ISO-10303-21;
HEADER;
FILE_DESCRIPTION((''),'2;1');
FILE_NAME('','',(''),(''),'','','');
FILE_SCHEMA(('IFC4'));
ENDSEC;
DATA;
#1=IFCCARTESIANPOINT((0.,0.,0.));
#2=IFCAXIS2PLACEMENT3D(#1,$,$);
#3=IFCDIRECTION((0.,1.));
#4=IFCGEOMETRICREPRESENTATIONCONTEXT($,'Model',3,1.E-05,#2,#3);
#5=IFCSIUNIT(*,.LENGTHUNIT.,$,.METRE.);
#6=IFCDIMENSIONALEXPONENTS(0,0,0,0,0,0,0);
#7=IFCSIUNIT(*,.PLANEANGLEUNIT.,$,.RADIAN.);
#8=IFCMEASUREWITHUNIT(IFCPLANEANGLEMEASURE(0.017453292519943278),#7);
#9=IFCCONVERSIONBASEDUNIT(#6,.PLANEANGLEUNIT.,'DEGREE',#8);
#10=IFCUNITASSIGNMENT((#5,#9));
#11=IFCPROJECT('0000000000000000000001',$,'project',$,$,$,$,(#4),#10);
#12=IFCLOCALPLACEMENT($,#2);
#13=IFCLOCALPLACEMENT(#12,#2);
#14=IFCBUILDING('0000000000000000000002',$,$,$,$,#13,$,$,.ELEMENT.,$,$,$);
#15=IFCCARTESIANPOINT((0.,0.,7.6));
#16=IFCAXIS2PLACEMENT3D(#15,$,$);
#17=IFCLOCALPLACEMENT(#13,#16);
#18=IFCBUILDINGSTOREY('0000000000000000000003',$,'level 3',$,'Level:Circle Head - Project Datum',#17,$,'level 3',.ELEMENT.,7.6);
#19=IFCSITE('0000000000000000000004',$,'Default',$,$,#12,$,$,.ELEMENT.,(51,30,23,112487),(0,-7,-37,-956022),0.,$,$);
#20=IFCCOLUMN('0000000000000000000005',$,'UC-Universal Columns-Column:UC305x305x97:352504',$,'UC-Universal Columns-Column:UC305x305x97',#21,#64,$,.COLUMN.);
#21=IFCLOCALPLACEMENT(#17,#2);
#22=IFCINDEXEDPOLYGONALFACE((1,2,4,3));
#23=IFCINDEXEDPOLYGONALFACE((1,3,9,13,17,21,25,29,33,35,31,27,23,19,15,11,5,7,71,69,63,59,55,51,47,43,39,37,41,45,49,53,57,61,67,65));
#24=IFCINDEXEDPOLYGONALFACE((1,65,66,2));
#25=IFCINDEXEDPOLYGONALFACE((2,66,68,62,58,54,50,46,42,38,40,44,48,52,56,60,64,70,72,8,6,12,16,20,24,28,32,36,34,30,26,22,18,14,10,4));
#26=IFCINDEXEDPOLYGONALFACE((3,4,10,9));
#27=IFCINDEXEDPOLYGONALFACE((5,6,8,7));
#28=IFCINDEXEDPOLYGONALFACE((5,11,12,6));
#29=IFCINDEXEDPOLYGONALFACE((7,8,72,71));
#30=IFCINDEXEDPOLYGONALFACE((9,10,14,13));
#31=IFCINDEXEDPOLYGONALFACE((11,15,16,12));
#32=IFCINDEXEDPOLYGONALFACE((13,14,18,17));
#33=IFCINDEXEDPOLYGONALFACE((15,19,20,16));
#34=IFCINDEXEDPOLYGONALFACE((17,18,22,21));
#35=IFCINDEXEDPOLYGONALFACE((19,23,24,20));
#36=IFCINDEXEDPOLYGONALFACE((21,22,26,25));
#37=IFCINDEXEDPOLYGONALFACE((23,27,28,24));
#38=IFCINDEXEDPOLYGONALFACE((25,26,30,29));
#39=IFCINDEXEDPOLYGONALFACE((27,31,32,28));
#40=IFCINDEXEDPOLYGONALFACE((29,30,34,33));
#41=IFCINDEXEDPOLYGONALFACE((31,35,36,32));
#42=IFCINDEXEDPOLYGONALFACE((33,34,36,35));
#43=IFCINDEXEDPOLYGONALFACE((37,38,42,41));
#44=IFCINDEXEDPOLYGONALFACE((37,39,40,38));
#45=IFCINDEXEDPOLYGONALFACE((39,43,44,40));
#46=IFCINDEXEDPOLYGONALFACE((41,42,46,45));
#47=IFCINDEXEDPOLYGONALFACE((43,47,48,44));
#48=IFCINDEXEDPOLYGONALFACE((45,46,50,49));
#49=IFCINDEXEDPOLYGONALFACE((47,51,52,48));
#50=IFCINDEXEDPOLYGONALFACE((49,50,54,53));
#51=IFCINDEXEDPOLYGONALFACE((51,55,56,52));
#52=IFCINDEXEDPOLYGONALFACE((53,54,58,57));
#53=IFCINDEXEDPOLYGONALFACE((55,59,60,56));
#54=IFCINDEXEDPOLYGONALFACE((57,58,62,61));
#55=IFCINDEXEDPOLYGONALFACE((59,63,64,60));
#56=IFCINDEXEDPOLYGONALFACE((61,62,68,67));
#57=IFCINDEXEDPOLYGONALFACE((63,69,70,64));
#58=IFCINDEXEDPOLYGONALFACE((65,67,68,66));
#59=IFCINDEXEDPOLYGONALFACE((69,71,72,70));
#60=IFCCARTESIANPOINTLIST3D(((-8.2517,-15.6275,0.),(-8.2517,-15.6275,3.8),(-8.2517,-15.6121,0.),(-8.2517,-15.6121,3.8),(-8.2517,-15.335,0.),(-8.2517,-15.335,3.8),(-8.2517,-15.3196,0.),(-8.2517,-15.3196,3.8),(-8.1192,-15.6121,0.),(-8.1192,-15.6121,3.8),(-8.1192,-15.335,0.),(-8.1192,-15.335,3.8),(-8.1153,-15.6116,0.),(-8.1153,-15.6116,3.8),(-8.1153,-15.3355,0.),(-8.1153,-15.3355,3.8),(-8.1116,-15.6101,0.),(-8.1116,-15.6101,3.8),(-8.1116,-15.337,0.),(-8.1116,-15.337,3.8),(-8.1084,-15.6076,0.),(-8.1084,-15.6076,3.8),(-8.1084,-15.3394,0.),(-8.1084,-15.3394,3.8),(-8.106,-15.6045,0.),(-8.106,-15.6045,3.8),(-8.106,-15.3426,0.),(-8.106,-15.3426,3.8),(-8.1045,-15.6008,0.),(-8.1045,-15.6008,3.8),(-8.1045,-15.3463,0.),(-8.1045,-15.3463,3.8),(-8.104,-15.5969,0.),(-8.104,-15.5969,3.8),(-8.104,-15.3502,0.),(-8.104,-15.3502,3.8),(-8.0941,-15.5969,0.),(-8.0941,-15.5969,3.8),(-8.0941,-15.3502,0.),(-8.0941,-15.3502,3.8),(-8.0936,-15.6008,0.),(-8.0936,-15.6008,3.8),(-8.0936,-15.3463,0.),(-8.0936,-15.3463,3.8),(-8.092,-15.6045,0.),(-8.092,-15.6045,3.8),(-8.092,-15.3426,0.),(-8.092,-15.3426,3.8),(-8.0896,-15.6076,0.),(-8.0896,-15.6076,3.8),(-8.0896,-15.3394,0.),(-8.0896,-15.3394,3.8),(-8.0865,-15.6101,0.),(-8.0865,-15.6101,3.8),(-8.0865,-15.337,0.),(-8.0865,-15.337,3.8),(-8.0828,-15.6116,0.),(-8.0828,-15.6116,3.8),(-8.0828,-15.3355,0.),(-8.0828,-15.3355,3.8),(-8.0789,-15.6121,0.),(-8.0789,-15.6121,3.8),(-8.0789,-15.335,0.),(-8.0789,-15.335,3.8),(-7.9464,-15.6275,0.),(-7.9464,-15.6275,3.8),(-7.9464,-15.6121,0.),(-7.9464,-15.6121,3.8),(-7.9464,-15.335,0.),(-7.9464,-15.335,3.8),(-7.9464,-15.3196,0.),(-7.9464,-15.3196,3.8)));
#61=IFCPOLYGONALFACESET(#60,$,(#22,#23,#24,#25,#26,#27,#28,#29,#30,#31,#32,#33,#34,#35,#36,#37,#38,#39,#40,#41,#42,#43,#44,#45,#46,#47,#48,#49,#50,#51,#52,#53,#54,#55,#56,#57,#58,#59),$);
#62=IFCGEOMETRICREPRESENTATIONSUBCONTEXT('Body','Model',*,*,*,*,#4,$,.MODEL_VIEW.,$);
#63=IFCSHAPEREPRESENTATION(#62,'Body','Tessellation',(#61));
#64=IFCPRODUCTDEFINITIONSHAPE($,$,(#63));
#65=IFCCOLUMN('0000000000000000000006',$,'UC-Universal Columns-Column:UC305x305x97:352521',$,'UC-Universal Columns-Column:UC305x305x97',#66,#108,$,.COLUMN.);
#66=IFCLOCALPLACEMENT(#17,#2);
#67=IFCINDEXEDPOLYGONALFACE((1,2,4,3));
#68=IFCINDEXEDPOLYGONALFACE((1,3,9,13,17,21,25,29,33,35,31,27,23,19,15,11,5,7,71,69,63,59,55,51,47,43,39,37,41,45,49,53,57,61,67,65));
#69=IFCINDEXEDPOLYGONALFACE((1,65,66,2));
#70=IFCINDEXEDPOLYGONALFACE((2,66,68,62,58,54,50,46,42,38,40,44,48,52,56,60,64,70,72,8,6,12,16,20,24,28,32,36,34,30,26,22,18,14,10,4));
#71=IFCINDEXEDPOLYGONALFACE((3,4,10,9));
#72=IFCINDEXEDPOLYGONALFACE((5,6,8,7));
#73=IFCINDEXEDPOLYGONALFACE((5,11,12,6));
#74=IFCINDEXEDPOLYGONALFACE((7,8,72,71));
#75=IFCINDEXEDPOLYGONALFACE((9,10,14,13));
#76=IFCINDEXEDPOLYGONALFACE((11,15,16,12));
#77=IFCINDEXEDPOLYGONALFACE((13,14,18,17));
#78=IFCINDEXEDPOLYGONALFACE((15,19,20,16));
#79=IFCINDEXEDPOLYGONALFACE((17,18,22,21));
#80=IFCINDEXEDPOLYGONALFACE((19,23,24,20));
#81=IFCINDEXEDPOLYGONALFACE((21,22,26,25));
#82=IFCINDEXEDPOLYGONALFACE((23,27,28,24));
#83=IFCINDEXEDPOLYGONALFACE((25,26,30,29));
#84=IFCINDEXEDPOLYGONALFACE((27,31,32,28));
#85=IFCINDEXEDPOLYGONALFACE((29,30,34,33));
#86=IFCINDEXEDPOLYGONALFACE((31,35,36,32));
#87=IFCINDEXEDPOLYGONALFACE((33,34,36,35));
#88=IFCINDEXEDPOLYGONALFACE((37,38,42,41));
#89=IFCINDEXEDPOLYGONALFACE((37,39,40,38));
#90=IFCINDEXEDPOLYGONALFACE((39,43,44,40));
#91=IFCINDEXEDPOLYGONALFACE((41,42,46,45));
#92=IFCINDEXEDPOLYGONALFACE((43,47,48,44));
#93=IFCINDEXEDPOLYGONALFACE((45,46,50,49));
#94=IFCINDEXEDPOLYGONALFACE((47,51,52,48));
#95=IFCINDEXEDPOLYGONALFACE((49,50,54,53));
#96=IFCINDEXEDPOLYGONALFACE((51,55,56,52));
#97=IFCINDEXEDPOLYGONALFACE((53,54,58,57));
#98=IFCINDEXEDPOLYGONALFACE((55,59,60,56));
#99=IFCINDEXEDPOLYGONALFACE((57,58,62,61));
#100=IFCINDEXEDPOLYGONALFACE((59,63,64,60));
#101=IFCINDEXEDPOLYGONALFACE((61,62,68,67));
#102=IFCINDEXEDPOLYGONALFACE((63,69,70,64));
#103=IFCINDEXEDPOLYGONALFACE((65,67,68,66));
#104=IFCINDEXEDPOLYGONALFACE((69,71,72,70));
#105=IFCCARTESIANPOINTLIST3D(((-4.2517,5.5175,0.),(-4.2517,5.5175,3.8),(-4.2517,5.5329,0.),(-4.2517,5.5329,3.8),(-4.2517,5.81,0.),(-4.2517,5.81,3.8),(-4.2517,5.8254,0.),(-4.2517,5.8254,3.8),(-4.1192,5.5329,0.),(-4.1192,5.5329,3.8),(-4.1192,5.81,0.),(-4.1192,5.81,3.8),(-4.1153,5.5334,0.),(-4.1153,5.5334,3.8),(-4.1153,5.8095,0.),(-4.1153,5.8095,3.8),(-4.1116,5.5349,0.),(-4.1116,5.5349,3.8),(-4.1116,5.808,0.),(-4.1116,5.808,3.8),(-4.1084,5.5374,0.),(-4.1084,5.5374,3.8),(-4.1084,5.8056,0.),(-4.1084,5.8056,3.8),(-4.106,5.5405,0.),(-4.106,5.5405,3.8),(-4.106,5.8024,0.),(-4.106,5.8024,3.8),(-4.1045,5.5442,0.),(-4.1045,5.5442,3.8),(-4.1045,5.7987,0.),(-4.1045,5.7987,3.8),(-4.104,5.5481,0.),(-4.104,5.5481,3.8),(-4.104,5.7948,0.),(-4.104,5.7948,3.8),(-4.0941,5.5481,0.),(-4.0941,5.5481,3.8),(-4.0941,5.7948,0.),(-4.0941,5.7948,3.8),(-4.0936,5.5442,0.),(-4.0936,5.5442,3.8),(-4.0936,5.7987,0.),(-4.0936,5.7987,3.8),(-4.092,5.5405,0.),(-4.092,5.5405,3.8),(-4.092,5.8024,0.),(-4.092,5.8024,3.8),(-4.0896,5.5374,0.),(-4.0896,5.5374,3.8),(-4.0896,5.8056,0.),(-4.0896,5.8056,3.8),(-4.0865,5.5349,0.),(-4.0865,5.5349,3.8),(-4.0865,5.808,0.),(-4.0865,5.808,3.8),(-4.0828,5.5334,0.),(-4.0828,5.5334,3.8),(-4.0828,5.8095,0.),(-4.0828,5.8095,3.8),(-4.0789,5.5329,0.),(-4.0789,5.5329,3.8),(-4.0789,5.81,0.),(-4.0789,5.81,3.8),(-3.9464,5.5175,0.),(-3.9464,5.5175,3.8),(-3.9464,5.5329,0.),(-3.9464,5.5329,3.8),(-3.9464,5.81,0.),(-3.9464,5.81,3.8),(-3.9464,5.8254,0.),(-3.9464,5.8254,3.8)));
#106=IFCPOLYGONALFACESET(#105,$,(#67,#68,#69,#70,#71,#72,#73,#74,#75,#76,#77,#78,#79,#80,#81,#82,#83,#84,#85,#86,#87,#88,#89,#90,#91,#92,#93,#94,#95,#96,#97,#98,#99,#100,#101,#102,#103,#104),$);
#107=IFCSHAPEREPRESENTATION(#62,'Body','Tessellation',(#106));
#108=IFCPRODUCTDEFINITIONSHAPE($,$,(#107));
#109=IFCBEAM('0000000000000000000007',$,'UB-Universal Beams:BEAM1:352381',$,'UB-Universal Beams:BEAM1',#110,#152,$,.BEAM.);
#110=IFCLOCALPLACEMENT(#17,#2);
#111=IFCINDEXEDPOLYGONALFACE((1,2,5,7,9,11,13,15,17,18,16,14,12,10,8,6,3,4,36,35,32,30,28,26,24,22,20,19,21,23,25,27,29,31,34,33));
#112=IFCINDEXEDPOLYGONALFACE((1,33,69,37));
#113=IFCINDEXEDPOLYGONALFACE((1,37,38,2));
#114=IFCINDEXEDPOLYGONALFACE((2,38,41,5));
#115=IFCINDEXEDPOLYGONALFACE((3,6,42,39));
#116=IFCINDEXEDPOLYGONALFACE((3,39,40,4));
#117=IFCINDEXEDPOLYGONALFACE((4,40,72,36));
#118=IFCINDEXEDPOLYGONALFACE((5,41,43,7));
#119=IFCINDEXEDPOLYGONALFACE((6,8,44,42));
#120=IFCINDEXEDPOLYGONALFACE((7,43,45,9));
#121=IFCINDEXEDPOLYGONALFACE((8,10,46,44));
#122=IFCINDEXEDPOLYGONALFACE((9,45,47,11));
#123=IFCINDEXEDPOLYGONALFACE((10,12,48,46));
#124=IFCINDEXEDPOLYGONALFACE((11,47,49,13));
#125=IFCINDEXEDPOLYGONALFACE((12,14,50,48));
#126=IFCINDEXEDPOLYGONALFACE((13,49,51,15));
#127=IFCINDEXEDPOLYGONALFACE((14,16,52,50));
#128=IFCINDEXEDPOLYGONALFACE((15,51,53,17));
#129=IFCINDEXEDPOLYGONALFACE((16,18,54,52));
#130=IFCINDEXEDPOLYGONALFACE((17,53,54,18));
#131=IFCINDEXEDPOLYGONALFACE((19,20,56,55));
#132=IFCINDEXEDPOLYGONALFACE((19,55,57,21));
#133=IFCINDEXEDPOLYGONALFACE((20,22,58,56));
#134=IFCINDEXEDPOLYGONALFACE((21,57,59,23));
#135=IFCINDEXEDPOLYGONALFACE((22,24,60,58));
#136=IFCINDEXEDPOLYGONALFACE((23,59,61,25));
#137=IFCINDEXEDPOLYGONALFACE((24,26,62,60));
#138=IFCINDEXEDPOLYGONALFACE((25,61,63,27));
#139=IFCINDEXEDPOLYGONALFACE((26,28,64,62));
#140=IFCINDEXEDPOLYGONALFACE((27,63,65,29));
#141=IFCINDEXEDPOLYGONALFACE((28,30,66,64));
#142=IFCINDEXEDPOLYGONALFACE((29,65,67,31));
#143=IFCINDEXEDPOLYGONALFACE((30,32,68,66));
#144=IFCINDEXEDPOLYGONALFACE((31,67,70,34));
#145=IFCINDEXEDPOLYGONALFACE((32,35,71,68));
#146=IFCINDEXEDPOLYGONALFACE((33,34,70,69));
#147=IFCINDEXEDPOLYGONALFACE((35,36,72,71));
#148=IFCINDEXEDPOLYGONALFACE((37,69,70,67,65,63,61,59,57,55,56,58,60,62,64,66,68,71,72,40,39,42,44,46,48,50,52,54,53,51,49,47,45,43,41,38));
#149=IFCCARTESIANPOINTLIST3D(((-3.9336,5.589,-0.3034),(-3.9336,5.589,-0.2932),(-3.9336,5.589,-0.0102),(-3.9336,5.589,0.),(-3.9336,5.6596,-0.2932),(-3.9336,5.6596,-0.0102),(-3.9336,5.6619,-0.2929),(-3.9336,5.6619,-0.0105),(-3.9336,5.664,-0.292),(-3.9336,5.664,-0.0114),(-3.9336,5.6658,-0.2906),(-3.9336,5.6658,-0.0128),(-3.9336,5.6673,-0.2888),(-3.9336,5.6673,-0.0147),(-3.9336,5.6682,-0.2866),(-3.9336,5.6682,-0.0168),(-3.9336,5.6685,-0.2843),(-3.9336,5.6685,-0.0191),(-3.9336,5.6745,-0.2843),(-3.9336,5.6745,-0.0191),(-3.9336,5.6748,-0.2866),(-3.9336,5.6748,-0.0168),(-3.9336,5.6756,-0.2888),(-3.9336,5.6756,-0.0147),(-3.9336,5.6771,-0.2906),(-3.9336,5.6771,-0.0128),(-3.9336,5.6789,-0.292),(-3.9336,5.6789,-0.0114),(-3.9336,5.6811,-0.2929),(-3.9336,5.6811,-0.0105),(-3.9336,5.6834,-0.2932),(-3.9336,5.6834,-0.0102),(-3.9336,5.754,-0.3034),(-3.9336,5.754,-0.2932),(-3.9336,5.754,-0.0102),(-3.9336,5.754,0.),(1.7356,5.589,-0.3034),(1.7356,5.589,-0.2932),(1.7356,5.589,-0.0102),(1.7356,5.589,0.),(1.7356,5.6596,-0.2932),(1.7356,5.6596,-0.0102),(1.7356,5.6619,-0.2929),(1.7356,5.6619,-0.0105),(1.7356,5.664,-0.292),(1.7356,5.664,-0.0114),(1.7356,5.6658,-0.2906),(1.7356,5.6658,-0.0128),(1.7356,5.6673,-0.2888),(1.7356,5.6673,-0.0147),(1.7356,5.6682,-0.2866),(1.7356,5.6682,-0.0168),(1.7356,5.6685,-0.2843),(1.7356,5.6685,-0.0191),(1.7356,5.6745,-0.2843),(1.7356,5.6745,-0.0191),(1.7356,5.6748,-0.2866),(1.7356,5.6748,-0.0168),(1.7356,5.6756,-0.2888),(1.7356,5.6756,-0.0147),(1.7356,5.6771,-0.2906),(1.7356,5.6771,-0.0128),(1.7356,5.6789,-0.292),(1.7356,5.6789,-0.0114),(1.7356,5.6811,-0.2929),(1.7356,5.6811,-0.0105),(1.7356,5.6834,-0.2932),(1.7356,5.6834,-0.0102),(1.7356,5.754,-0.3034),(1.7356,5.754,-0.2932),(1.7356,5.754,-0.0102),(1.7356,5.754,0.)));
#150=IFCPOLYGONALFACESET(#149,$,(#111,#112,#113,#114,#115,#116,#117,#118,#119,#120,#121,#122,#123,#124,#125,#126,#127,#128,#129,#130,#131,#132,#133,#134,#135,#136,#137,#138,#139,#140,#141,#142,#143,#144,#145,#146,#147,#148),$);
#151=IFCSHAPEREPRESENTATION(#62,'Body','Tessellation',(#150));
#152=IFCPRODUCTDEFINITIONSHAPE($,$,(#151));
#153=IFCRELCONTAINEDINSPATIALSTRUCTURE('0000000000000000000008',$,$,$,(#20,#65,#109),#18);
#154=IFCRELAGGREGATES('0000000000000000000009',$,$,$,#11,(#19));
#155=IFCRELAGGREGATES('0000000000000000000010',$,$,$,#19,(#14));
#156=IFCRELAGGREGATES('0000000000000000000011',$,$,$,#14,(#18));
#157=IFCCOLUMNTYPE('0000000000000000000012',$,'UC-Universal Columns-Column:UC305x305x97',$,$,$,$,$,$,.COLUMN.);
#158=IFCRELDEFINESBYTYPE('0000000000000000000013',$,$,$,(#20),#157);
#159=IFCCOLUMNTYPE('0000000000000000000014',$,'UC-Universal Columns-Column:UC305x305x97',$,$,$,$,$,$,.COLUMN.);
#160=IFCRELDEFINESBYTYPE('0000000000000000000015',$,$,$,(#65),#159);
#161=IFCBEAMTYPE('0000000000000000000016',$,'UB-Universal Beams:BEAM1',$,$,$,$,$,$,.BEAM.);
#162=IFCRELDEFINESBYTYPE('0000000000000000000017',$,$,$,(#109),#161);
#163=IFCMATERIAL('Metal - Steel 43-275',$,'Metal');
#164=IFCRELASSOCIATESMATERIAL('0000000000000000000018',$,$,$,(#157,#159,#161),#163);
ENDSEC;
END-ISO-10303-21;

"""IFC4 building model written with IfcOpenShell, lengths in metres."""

from ifc_helpers import new_model, entity, si_unit, converted_unit, direction, frame, frame_2d, origin, place, context, subcontext, project, spatial, polyline, circle_curve, parameter, trimmed, segment, composite_curve, i_section, outline, extrude, source, transform, mapped, material, material_profile, profile_set, type_object, type_shapes, element, save


model = new_model("IFC4")

# Units and contexts
model_context = context("Model", 3, precision=1e-05, world=origin(), true_north=direction((0.0, 1.0)))
body_context = subcontext(model_context, "Body", "Model", "MODEL_VIEW")
ifc_project = project(units=[si_unit("LENGTHUNIT", "METRE"), converted_unit("PLANEANGLEUNIT", "DEGREE", entity("IfcPlaneAngleMeasure", 0.017453292519943278), si_unit("PLANEANGLEUNIT", "RADIAN"), dimensions=[0, 0, 0, 0, 0, 0, 0])], contexts=[model_context])

# Site, building, storey
site_placement = place(None, origin())
site = spatial("IfcSite", under=ifc_project, at=site_placement, Name="Default", CompositionType="ELEMENT", RefLatitude=(51, 30, 23, 112487), RefLongitude=(0, -7, -37, -956022), RefElevation=0.0)
building_placement = place(site_placement, origin())
building = spatial("IfcBuilding", under=site, at=building_placement, CompositionType="ELEMENT")
storey_placement = place(building_placement, frame((0.0, 0.0, 7.6)))
storey = spatial("IfcBuildingStorey", under=building, at=storey_placement, Name="level 3", ObjectType="Level:Circle Head - Project Datum", LongName="level 3", CompositionType="ELEMENT", Elevation=7.6)

# Columns
ifc_material_1 = material(Name="Metal - Steel 43-275", Category="Metal")
ifc_material_profile_1 = material_profile(ifc_material_1, i_section(OverallWidth=0.3053, OverallDepth=0.3079, WebThickness=0.0099, FlangeThickness=0.0154, FilletRadius=0.0152, at=frame_2d((0.0, 0.0), x_axis=(1.0, 0.0))), Name="UC305x305x97")
ifc_profile_set_1 = profile_set([ifc_material_profile_1], Name="UC305x305x97")
column_type_1 = type_object("IfcColumnType", Name="UC-Universal Columns-Column:UC305x305x97", PredefinedType="COLUMN", material=ifc_profile_set_1)
shared_shape_1 = source(origin(), body_context, "Body", "SweptSolid", [
    extrude(i_section(OverallWidth=0.3053, OverallDepth=0.3079, WebThickness=0.0099, FlangeThickness=0.0154, FilletRadius=0.0152, at=frame_2d((0.0, 0.0), x_axis=(1.0, 0.0))), frame((-8.099, -15.4735, 7.6), z_axis=(0.0, 0.0, 1.0), x_axis=(-1.0, 0.0, 0.0)), (0.0, 0.0, 1.0), 3.8),
])
type_shapes(column_type_1, [shared_shape_1])
column_1_placement = place(storey_placement, frame((0.0, 0.0, -7.6)))
element("IfcColumn", 1, at=column_1_placement, inside=storey, type_object=column_type_1, Name="UC-Universal Columns-Column:UC305x305x97:352504", ObjectType="UC-Universal Columns-Column:UC305x305x97", PredefinedType="COLUMN", context=body_context, shape_type="MappedRepresentation", body=[
    mapped(shared_shape_1, transform((0.0, 0.0, 0.0), scale=1.0)),
])
column_type_2 = type_object("IfcColumnType", Name="UC-Universal Columns-Column:UC305x305x97", PredefinedType="COLUMN", material=ifc_profile_set_1)
shared_shape_2 = source(origin(), body_context, "Body", "SweptSolid", [
    extrude(i_section(OverallWidth=0.3053, OverallDepth=0.3079, WebThickness=0.0099, FlangeThickness=0.0154, FilletRadius=0.0152, at=frame_2d((0.0, 0.0), x_axis=(1.0, 0.0))), frame((-4.099, 5.6715, 7.6), z_axis=(0.0, 0.0, 1.0), x_axis=(-1.0, 0.0, 0.0)), (0.0, 0.0, 1.0), 3.8),
])
type_shapes(column_type_2, [shared_shape_2])
column_2_placement = place(storey_placement, frame((0.0, 0.0, -7.6)))
element("IfcColumn", 2, at=column_2_placement, inside=storey, type_object=column_type_2, Name="UC-Universal Columns-Column:UC305x305x97:352521", ObjectType="UC-Universal Columns-Column:UC305x305x97", PredefinedType="COLUMN", context=body_context, shape_type="MappedRepresentation", body=[
    mapped(shared_shape_2, transform((0.0, 0.0, 0.0), scale=1.0)),
])

# Beam
ifc_material_profile_2 = material_profile(ifc_material_1, outline(composite_curve([segment(polyline([(-0.0825, -0.1415), (-0.0825, -0.1517)]), True, "CONTINUOUS"), segment(polyline([(-0.0825, -0.1517), (0.0825, -0.1517)]), True, "CONTINUOUS"), segment(polyline([(0.0825, -0.1517), (0.0825, -0.1415)]), True, "CONTINUOUS"), segment(polyline([(0.0825, -0.1415), (0.0119, -0.1415)]), True, "CONTINUOUS"), segment(trimmed(circle_curve(frame_2d((0.0119, -0.1326), x_axis=(1.0, 0.0)), 0.0089), [parameter(180.0)], [parameter(270.0)], True, "PARAMETER"), False, "CONTINUOUS"), segment(polyline([(0.003, -0.1326), (0.003, 0.1326)]), True, "CONTINUOUS"), segment(trimmed(circle_curve(frame_2d((0.0119, 0.1326), x_axis=(1.0, 0.0)), 0.0089), [parameter(90.0)], [parameter(180.0)], True, "PARAMETER"), False, "CONTINUOUS"), segment(polyline([(0.0119, 0.1415), (0.0825, 0.1415)]), True, "CONTINUOUS"), segment(polyline([(0.0825, 0.1415), (0.0825, 0.1517)]), True, "CONTINUOUS"), segment(polyline([(0.0825, 0.1517), (-0.0825, 0.1517)]), True, "CONTINUOUS"), segment(polyline([(-0.0825, 0.1517), (-0.0825, 0.1415)]), True, "CONTINUOUS"), segment(polyline([(-0.0825, 0.1415), (-0.0119, 0.1415)]), True, "CONTINUOUS"), segment(trimmed(circle_curve(frame_2d((-0.0119, 0.1326), x_axis=(1.0, 0.0)), 0.0089), [parameter(360.0)], [parameter(90.0)], True, "PARAMETER"), False, "CONTINUOUS"), segment(polyline([(-0.003, 0.1326), (-0.003, -0.1326)]), True, "CONTINUOUS"), segment(trimmed(circle_curve(frame_2d((-0.0119, -0.1326), x_axis=(1.0, 0.0)), 0.0089), [parameter(270.0)], [parameter(360.0)], True, "PARAMETER"), False, "CONTINUOUS"), segment(polyline([(-0.0119, -0.1415), (-0.0825, -0.1415)]), True, "CONTINUOUS")], self_intersect=False)), Name="BEAM1")
ifc_profile_set_2 = profile_set([ifc_material_profile_2], Name="BEAM1")
beam_type_1 = type_object("IfcBeamType", Name="UB-Universal Beams:BEAM1", PredefinedType="BEAM", material=ifc_profile_set_2)
shared_shape_3 = source(origin(), body_context, "Body", "SweptSolid", [
    extrude(outline(composite_curve([segment(polyline([(-0.0825, -0.1415), (-0.0825, -0.1517)]), True, "CONTINUOUS"), segment(polyline([(-0.0825, -0.1517), (0.0825, -0.1517)]), True, "CONTINUOUS"), segment(polyline([(0.0825, -0.1517), (0.0825, -0.1415)]), True, "CONTINUOUS"), segment(polyline([(0.0825, -0.1415), (0.0119, -0.1415)]), True, "CONTINUOUS"), segment(trimmed(circle_curve(frame_2d((0.0119, -0.1326), x_axis=(0.0, -1.0)), 0.0089), [parameter(270.0)], [parameter(360.0)], True, "PARAMETER"), False, "CONTINUOUS"), segment(polyline([(0.003, -0.1326), (0.003, 0.1326)]), True, "CONTINUOUS"), segment(trimmed(circle_curve(frame_2d((0.0119, 0.1326), x_axis=(-1.0, 0.0)), 0.0089), [parameter(270.0)], [parameter(360.0)], True, "PARAMETER"), False, "CONTINUOUS"), segment(polyline([(0.0119, 0.1415), (0.0825, 0.1415)]), True, "CONTINUOUS"), segment(polyline([(0.0825, 0.1415), (0.0825, 0.1517)]), True, "CONTINUOUS"), segment(polyline([(0.0825, 0.1517), (-0.0825, 0.1517)]), True, "CONTINUOUS"), segment(polyline([(-0.0825, 0.1517), (-0.0825, 0.1415)]), True, "CONTINUOUS"), segment(polyline([(-0.0825, 0.1415), (-0.0119, 0.1415)]), True, "CONTINUOUS"), segment(trimmed(circle_curve(frame_2d((-0.0119, 0.1326), x_axis=(0.0, 1.0)), 0.0089), [parameter(270.0)], [parameter(360.0)], True, "PARAMETER"), False, "CONTINUOUS"), segment(polyline([(-0.003, 0.1326), (-0.003, -0.1326)]), True, "CONTINUOUS"), segment(trimmed(circle_curve(frame_2d((-0.0119, -0.1326), x_axis=(1.0, 0.0)), 0.0089), [parameter(270.0)], [parameter(0.0)], True, "PARAMETER"), False, "CONTINUOUS"), segment(polyline([(-0.0119, -0.1415), (-0.0825, -0.1415)]), True, "CONTINUOUS")], self_intersect=False)), frame((-2.8346, 0.0, 0.0), z_axis=(-1.0, 0.0, 0.0), x_axis=(0.0, -1.0, 0.0)), (0.0, 0.0, -1.0), 5.6692),
])
type_shapes(beam_type_1, [shared_shape_3])
beam_1_placement = place(storey_placement, frame((-1.099, 5.6715, -0.1517), z_axis=(0.0, 0.0, 1.0), x_axis=(-1.0, 0.0, 0.0)))
element("IfcBeam", 3, at=beam_1_placement, inside=storey, type_object=beam_type_1, Name="UB-Universal Beams:BEAM1:352381", ObjectType="UB-Universal Beams:BEAM1", PredefinedType="BEAM", context=body_context, shape_type="MappedRepresentation", body=[
    mapped(shared_shape_3, transform((0.0, 0.0, 0.0), scale=1.0)),
])

save(model, "model.ifc")
